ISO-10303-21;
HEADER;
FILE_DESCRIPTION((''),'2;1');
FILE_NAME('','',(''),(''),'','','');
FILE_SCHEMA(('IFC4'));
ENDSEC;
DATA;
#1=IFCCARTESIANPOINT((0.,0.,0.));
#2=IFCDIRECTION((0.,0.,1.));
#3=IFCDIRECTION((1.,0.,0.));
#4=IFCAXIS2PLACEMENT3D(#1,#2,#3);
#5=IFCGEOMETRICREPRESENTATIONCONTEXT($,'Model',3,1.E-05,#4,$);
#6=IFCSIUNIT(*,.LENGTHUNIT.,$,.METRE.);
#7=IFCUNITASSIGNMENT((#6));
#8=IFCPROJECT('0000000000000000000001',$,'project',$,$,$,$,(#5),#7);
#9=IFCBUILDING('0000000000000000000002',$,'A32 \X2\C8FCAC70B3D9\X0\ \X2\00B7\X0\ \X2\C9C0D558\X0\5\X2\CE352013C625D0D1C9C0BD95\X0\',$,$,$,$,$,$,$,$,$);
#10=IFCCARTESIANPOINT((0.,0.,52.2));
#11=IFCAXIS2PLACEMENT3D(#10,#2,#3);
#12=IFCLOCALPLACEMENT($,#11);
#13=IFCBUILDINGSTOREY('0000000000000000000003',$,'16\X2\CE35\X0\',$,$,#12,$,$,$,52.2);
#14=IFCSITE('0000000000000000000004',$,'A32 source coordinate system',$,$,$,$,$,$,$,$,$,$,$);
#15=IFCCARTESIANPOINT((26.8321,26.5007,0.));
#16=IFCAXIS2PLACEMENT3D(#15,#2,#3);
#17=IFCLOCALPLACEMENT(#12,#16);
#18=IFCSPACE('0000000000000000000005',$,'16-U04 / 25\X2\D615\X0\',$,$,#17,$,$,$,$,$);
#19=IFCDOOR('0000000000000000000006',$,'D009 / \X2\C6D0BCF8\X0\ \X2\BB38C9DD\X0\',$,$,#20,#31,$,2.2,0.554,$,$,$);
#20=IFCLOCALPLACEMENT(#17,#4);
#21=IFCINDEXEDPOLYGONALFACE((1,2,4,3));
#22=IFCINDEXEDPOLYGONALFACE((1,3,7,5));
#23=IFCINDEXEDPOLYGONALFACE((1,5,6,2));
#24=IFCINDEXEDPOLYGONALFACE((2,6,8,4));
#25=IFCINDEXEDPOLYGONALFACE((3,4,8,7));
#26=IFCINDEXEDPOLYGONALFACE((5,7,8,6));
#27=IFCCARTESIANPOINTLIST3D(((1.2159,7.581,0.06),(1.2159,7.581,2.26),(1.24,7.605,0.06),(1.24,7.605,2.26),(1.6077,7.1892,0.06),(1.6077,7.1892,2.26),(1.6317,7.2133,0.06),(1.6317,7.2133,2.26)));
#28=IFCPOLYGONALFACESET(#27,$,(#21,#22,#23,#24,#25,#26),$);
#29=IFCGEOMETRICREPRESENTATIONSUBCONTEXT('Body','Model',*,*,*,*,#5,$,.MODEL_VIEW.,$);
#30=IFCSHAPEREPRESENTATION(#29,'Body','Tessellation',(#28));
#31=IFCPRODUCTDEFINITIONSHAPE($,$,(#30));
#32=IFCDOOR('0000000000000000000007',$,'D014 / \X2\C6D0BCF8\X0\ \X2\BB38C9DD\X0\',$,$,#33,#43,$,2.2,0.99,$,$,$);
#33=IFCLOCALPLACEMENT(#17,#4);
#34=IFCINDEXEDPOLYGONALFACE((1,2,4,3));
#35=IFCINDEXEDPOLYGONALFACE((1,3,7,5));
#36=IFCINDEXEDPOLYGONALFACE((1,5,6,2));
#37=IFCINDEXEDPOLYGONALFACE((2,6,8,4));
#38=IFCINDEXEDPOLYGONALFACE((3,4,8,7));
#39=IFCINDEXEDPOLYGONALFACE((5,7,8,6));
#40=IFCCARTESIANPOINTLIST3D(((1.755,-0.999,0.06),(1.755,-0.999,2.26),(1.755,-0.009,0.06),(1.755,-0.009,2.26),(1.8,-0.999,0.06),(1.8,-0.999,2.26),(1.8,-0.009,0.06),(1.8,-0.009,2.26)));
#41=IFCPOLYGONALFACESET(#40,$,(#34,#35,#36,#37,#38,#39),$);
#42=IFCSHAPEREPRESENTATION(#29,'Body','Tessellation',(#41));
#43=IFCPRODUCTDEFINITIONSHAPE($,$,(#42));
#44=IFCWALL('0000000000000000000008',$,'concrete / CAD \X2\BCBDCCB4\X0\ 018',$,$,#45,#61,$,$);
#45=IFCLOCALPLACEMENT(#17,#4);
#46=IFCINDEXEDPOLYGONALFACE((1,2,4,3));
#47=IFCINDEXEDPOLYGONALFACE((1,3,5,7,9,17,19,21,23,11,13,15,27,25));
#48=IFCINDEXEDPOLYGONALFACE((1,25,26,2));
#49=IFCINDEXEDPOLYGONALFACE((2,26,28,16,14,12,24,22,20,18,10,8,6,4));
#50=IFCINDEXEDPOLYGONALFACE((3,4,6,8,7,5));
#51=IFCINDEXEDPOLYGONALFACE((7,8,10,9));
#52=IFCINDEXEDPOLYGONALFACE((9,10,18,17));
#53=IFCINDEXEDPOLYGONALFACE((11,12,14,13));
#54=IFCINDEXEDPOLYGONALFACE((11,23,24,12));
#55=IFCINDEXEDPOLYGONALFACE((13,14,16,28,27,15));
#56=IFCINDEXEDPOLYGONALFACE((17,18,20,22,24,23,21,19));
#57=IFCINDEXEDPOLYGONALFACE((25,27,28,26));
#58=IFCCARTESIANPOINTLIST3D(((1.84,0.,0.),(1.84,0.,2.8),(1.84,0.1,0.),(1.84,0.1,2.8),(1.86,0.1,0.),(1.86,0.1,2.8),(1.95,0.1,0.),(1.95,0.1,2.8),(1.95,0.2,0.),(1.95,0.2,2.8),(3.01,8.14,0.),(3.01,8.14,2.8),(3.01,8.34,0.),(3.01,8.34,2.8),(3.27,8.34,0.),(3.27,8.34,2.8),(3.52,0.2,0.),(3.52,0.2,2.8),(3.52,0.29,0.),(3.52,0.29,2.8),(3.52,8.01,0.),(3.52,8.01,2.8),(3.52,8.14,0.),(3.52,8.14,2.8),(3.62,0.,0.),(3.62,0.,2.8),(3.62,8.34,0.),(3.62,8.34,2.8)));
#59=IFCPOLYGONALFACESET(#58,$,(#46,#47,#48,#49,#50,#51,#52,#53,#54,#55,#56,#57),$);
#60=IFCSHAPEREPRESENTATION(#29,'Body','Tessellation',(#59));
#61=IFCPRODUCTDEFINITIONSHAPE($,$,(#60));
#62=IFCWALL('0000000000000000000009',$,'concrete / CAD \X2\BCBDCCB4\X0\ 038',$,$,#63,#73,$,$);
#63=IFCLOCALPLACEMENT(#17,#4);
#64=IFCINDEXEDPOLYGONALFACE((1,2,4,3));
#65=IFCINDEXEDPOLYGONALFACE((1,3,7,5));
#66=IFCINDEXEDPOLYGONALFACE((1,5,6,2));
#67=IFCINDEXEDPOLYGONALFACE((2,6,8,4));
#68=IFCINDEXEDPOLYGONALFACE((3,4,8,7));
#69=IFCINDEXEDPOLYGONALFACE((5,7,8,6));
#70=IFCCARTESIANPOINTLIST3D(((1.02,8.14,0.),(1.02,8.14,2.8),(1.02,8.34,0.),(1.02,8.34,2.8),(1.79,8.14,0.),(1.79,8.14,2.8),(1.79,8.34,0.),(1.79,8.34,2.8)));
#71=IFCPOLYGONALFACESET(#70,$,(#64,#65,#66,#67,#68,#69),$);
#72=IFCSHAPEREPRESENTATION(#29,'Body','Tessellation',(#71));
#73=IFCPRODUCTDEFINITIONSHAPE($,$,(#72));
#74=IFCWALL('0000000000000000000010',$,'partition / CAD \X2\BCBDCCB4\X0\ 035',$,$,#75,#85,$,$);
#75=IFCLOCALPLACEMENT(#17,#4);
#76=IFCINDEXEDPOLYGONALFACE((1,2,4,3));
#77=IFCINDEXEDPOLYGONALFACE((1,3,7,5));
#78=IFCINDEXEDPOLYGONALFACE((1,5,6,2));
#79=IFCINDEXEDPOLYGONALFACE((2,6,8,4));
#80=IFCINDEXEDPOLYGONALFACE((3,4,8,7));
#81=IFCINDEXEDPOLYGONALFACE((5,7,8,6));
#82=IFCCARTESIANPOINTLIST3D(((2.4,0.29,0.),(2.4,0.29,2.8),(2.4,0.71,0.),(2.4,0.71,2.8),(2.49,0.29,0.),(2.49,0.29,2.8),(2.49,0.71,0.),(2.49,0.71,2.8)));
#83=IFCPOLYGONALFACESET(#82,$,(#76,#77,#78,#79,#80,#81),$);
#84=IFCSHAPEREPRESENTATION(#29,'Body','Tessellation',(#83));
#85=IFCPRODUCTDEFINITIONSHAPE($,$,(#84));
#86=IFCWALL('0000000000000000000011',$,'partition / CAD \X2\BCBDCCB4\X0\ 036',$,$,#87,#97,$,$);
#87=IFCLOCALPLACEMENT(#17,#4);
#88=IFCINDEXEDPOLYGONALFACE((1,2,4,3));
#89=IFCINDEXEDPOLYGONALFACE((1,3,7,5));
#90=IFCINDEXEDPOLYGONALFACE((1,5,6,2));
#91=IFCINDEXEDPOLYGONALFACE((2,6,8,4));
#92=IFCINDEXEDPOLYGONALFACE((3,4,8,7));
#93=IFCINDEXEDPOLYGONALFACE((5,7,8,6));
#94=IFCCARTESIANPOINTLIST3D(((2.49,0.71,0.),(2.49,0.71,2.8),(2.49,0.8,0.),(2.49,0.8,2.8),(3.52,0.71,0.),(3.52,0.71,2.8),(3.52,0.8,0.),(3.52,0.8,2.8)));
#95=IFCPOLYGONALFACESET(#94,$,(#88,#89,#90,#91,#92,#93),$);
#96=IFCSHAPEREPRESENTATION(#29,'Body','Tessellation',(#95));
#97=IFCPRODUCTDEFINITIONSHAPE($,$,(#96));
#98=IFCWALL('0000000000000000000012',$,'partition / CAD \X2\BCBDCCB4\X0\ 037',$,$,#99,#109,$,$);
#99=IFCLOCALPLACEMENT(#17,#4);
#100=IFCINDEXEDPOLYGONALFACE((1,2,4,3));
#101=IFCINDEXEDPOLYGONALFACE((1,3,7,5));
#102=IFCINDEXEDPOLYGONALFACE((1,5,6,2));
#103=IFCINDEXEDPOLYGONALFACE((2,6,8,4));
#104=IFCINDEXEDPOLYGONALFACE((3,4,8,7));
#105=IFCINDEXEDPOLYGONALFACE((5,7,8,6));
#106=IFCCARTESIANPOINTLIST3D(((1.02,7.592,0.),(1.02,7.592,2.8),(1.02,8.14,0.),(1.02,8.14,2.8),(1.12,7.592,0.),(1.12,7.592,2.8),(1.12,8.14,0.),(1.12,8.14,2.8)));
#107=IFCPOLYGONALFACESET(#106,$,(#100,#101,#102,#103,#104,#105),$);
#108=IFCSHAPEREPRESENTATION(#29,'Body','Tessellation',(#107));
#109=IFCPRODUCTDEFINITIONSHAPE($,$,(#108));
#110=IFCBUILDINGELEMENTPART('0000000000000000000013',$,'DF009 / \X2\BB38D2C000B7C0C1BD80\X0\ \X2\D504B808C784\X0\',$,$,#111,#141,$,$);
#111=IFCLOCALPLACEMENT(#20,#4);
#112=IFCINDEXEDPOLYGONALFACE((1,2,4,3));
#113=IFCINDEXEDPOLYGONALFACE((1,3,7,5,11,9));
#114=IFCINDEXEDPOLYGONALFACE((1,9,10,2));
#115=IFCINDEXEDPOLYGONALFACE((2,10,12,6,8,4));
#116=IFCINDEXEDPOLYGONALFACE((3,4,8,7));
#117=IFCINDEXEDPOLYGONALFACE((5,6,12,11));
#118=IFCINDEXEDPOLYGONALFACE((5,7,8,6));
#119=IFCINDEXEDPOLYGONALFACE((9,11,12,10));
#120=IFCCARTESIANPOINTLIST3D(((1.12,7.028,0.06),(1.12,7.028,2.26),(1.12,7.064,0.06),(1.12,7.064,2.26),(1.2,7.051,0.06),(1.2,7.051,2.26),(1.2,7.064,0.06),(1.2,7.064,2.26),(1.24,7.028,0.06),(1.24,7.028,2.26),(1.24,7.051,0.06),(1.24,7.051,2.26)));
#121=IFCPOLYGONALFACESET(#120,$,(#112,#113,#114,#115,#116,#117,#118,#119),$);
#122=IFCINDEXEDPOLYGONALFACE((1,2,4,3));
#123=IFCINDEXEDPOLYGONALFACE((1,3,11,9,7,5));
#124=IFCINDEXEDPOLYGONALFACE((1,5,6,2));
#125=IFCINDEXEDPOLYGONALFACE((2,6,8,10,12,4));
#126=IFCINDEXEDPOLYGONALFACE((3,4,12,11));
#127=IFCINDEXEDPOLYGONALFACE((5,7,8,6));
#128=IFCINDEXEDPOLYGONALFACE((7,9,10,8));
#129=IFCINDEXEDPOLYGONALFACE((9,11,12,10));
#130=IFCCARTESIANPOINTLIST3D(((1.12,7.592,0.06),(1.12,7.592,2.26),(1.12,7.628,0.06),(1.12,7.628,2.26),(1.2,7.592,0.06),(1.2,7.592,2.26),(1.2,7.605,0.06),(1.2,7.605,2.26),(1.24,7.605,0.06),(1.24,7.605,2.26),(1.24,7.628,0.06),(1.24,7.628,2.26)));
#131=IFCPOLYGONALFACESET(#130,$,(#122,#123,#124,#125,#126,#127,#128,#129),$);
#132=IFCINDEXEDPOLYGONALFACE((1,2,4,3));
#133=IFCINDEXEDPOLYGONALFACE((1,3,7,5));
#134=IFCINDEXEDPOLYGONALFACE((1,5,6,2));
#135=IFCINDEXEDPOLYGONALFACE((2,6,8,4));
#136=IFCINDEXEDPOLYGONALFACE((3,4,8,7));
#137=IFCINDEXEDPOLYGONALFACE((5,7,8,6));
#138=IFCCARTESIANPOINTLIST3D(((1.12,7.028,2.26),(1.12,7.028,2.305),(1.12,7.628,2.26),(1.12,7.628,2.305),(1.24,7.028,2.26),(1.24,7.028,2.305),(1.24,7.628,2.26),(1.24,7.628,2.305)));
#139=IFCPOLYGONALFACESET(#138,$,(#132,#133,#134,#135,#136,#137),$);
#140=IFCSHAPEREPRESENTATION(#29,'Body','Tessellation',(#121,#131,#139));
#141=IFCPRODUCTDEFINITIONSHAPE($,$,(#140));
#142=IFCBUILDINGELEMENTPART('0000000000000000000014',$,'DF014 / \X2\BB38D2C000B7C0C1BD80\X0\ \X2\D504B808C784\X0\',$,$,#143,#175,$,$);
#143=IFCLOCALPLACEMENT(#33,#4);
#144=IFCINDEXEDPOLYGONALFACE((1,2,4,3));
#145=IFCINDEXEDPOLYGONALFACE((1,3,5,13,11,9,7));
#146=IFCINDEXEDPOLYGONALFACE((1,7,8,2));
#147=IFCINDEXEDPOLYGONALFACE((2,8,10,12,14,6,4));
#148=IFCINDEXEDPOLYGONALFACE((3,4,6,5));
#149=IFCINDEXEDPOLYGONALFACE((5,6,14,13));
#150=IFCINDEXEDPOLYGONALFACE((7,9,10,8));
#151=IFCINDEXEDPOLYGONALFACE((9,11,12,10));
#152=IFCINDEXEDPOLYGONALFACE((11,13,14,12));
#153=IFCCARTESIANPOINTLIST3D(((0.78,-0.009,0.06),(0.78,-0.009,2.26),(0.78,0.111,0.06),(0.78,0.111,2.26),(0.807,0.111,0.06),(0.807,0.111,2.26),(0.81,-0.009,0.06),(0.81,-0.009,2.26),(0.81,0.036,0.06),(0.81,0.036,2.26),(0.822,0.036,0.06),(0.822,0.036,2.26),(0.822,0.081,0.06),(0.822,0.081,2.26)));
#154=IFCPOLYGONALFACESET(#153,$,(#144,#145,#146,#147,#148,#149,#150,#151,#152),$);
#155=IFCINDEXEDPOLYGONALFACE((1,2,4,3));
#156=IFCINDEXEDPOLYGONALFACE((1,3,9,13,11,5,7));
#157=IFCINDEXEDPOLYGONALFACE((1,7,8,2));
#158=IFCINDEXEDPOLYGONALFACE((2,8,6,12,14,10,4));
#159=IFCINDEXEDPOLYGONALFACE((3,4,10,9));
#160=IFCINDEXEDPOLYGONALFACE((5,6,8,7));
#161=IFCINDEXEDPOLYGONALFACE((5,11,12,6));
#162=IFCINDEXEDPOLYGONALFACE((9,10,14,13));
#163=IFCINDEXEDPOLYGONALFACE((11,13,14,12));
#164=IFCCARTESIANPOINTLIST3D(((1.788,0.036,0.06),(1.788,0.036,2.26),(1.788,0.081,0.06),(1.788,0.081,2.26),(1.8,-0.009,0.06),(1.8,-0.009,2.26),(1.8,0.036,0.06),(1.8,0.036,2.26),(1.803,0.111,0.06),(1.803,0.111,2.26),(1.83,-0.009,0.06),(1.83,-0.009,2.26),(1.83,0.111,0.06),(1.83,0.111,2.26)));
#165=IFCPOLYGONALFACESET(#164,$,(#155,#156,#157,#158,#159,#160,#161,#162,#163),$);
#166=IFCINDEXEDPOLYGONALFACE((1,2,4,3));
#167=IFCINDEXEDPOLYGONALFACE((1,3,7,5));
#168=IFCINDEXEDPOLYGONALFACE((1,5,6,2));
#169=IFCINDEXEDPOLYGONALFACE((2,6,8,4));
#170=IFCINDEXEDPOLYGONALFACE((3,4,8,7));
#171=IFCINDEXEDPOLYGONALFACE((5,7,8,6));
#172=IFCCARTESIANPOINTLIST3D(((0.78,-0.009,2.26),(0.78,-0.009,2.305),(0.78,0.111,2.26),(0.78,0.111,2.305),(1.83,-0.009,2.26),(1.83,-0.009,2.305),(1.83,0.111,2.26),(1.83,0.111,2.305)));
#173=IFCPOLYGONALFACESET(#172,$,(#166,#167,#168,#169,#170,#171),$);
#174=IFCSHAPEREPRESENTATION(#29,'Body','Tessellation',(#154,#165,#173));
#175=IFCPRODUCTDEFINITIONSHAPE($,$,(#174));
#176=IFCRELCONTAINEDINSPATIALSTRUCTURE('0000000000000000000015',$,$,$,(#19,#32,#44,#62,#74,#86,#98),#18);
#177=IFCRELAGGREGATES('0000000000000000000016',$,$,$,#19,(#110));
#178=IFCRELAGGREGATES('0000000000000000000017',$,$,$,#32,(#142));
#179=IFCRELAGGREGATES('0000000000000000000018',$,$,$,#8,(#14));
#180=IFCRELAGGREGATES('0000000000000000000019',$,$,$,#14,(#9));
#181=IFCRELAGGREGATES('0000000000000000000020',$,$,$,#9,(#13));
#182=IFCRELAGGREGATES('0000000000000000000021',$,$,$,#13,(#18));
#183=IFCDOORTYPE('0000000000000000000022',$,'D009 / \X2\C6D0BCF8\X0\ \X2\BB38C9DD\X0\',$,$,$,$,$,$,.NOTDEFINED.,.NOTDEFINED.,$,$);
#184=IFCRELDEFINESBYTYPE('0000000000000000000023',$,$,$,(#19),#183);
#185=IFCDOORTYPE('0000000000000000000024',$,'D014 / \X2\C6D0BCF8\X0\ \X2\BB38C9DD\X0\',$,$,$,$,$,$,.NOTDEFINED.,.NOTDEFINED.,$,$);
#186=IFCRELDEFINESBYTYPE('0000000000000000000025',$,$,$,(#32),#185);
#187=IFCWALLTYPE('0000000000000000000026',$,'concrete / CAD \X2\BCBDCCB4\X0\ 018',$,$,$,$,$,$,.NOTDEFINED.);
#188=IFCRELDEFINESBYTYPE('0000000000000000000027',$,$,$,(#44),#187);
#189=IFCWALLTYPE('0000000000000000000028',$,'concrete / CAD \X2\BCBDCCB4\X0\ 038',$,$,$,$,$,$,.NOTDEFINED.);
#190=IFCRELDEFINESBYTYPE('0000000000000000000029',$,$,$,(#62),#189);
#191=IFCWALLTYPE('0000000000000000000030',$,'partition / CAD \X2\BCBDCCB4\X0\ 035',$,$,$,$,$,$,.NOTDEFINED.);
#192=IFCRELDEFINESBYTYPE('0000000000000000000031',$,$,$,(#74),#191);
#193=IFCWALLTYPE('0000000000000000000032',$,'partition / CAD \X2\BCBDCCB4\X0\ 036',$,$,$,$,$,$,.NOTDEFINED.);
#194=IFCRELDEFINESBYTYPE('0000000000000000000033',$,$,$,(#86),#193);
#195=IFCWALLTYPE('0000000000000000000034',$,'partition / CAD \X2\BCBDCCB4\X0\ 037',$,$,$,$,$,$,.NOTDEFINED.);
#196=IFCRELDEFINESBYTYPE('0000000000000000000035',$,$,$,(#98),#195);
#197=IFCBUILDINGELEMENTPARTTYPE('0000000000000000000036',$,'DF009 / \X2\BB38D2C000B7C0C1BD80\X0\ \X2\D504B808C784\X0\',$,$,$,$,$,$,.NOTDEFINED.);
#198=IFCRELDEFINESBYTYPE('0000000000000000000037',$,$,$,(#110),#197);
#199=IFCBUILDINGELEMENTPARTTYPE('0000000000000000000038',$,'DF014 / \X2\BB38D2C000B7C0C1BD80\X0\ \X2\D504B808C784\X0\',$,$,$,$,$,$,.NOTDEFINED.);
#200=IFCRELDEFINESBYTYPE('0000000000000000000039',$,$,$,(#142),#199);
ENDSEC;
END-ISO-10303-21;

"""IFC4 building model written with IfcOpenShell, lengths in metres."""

from ifc_helpers import new_model, si_unit, frame, origin, origin_with_axes, place, context, subcontext, project, spatial, polyline, outline, extrude, source, transform, mapped, type_object, type_shapes, element, aggregate, save


model = new_model("IFC4")

# Units and contexts
model_context = context("Model", 3, precision=1e-05, world=origin_with_axes())
body_context = subcontext(model_context, "Body", "Model", "MODEL_VIEW")
ifc_project = project(units=[si_unit("LENGTHUNIT", "METRE")], contexts=[model_context])

# Site, building, storey, space
storey_placement = place(None, frame((0.0, 0.0, 52.2), z_axis=(0.0, 0.0, 1.0), x_axis=(1.0, 0.0, 0.0)))
space_placement = place(storey_placement, frame((26.8321, 26.5007, 0.0), z_axis=(0.0, 0.0, 1.0), x_axis=(1.0, 0.0, 0.0)))
site = spatial("IfcSite", under=ifc_project, Name="A32 source coordinate system")
building = spatial("IfcBuilding", under=site, Name="A32 주거동 · 지하5층–옥탑지붕")
storey = spatial("IfcBuildingStorey", under=building, at=storey_placement, Name="16층", Elevation=52.2)
space = spatial("IfcSpace", under=storey, at=space_placement, Name="16-U04 / 25형")

# Doors
door_type_1 = type_object("IfcDoorType", Name="D009 / 원본 문짝", OperationType="NOTDEFINED", PredefinedType="NOTDEFINED")
shared_shape_1 = source(origin(), body_context, "Body", "SweptSolid", [
    extrude(outline(polyline([(1.24, 7.605), (1.6317, 7.2133), (1.6077, 7.1892), (1.2159, 7.581), (1.24, 7.605)])), frame((0.0, 0.0, 0.06)), (0.0, 0.0, 1.0), 2.2),
])
type_shapes(door_type_1, [shared_shape_1])
door_1_placement = place(space_placement, origin_with_axes())
door_1 = element("IfcDoor", 1, at=door_1_placement, inside=space, type_object=door_type_1, Name="D009 / 원본 문짝", OverallHeight=2.2, OverallWidth=0.554, context=body_context, shape_type="MappedRepresentation", body=[
    mapped(shared_shape_1, transform((0.0, 0.0, 0.0), scale=1.0)),
])
door_type_2 = type_object("IfcDoorType", Name="D014 / 원본 문짝", OperationType="NOTDEFINED", PredefinedType="NOTDEFINED")
shared_shape_2 = source(origin(), body_context, "Body", "SweptSolid", [
    extrude(outline(polyline([(1.8, -0.009), (1.8, -0.999), (1.755, -0.999), (1.755, -0.009), (1.8, -0.009)])), frame((0.0, 0.0, 0.06)), (0.0, 0.0, 1.0), 2.2),
])
type_shapes(door_type_2, [shared_shape_2])
door_2_placement = place(space_placement, origin_with_axes())
door_2 = element("IfcDoor", 2, at=door_2_placement, inside=space, type_object=door_type_2, Name="D014 / 원본 문짝", OverallHeight=2.2, OverallWidth=0.99, context=body_context, shape_type="MappedRepresentation", body=[
    mapped(shared_shape_2, transform((0.0, 0.0, 0.0), scale=1.0)),
])

# Walls
wall_type_1 = type_object("IfcWallType", Name="concrete / CAD 벽체 018", PredefinedType="NOTDEFINED")
shared_shape_3 = source(origin(), body_context, "Body", "SweptSolid", [
    extrude(outline(polyline([(3.27, 8.34), (3.27, 8.34), (3.62, 8.34), (3.62, 0.0), (1.84, 0.0), (1.84, 0.1), (1.86, 0.1), (1.95, 0.1), (1.95, 0.2), (3.52, 0.2), (3.52, 0.29), (3.52, 8.01), (3.52, 8.14), (3.01, 8.14), (3.01, 8.34), (3.27, 8.34)])), origin(), (0.0, 0.0, 1.0), 2.8),
])
type_shapes(wall_type_1, [shared_shape_3])
wall_1_placement = place(space_placement, origin_with_axes())
element("IfcWall", 3, at=wall_1_placement, inside=space, type_object=wall_type_1, Name="concrete / CAD 벽체 018", context=body_context, shape_type="MappedRepresentation", body=[
    mapped(shared_shape_3, transform((0.0, 0.0, 0.0), scale=1.0)),
])
wall_type_2 = type_object("IfcWallType", Name="concrete / CAD 벽체 038", PredefinedType="NOTDEFINED")
shared_shape_4 = source(origin(), body_context, "Body", "SweptSolid", [
    extrude(outline(polyline([(1.02, 8.14), (1.02, 8.34), (1.79, 8.34), (1.79, 8.14), (1.02, 8.14)])), origin(), (0.0, 0.0, 1.0), 2.8),
])
type_shapes(wall_type_2, [shared_shape_4])
wall_2_placement = place(space_placement, origin_with_axes())
element("IfcWall", 4, at=wall_2_placement, inside=space, type_object=wall_type_2, Name="concrete / CAD 벽체 038", context=body_context, shape_type="MappedRepresentation", body=[
    mapped(shared_shape_4, transform((0.0, 0.0, 0.0), scale=1.0)),
])
wall_type_3 = type_object("IfcWallType", Name="partition / CAD 벽체 035", PredefinedType="NOTDEFINED")
shared_shape_5 = source(origin(), body_context, "Body", "SweptSolid", [
    extrude(outline(polyline([(2.49, 0.71), (2.49, 0.29), (2.4, 0.29), (2.4, 0.71), (2.49, 0.71)])), origin(), (0.0, 0.0, 1.0), 2.8),
])
type_shapes(wall_type_3, [shared_shape_5])
wall_3_placement = place(space_placement, origin_with_axes())
element("IfcWall", 5, at=wall_3_placement, inside=space, type_object=wall_type_3, Name="partition / CAD 벽체 035", context=body_context, shape_type="MappedRepresentation", body=[
    mapped(shared_shape_5, transform((0.0, 0.0, 0.0), scale=1.0)),
])
wall_type_4 = type_object("IfcWallType", Name="partition / CAD 벽체 036", PredefinedType="NOTDEFINED")
shared_shape_6 = source(origin(), body_context, "Body", "SweptSolid", [
    extrude(outline(polyline([(2.49, 0.8), (3.52, 0.8), (3.52, 0.71), (2.49, 0.71), (2.49, 0.8)])), origin(), (0.0, 0.0, 1.0), 2.8),
])
type_shapes(wall_type_4, [shared_shape_6])
wall_4_placement = place(space_placement, origin_with_axes())
element("IfcWall", 6, at=wall_4_placement, inside=space, type_object=wall_type_4, Name="partition / CAD 벽체 036", context=body_context, shape_type="MappedRepresentation", body=[
    mapped(shared_shape_6, transform((0.0, 0.0, 0.0), scale=1.0)),
])
wall_type_5 = type_object("IfcWallType", Name="partition / CAD 벽체 037", PredefinedType="NOTDEFINED")
shared_shape_7 = source(origin(), body_context, "Body", "SweptSolid", [
    extrude(outline(polyline([(1.02, 7.592), (1.02, 8.14), (1.12, 8.14), (1.12, 7.592), (1.02, 7.592)])), origin(), (0.0, 0.0, 1.0), 2.8),
])
type_shapes(wall_type_5, [shared_shape_7])
wall_5_placement = place(space_placement, origin_with_axes())
element("IfcWall", 7, at=wall_5_placement, inside=space, type_object=wall_type_5, Name="partition / CAD 벽체 037", context=body_context, shape_type="MappedRepresentation", body=[
    mapped(shared_shape_7, transform((0.0, 0.0, 0.0), scale=1.0)),
])

# Building element parts
building_element_part_type_1 = type_object("IfcBuildingElementPartType", Name="DF009 / 문틀·상부 프레임", PredefinedType="NOTDEFINED")
shared_shape_8 = source(origin(), body_context, "Body", "SweptSolid", [
    extrude(outline(polyline([(1.12, 7.064), (1.2, 7.064), (1.2, 7.051), (1.24, 7.051), (1.24, 7.028), (1.12, 7.028), (1.12, 7.064)])), frame((0.0, 0.0, 0.06)), (0.0, 0.0, 1.0), 2.2),
    extrude(outline(polyline([(1.24, 7.628), (1.24, 7.605), (1.2, 7.605), (1.2, 7.592), (1.12, 7.592), (1.12, 7.628), (1.24, 7.628)])), frame((0.0, 0.0, 0.06)), (0.0, 0.0, 1.0), 2.2),
    extrude(outline(polyline([(1.12, 7.028), (1.12, 7.628), (1.24, 7.628), (1.24, 7.028), (1.12, 7.028)])), frame((0.0, 0.0, 2.26)), (0.0, 0.0, 1.0), 0.045),
])
type_shapes(building_element_part_type_1, [shared_shape_8])
building_element_part_1_placement = place(door_1_placement, origin_with_axes())
building_element_part_1 = element("IfcBuildingElementPart", 8, at=building_element_part_1_placement, type_object=building_element_part_type_1, Name="DF009 / 문틀·상부 프레임", context=body_context, shape_type="MappedRepresentation", body=[
    mapped(shared_shape_8, transform((0.0, 0.0, 0.0), scale=1.0)),
])
aggregate(door_1, [building_element_part_1])
building_element_part_type_2 = type_object("IfcBuildingElementPartType", Name="DF014 / 문틀·상부 프레임", PredefinedType="NOTDEFINED")
shared_shape_9 = source(origin(), body_context, "Body", "SweptSolid", [
    extrude(outline(polyline([(0.78, 0.111), (0.807, 0.111), (0.822, 0.081), (0.822, 0.036), (0.81, 0.036), (0.81, -0.009), (0.78, -0.009), (0.78, 0.111)])), frame((0.0, 0.0, 0.06)), (0.0, 0.0, 1.0), 2.2),
    extrude(outline(polyline([(1.8, -0.009), (1.8, 0.036), (1.788, 0.036), (1.788, 0.081), (1.803, 0.111), (1.83, 0.111), (1.83, -0.009), (1.8, -0.009)])), frame((0.0, 0.0, 0.06)), (0.0, 0.0, 1.0), 2.2),
    extrude(outline(polyline([(0.78, -0.009), (0.78, 0.111), (1.83, 0.111), (1.83, -0.009), (0.78, -0.009)])), frame((0.0, 0.0, 2.26)), (0.0, 0.0, 1.0), 0.045),
])
type_shapes(building_element_part_type_2, [shared_shape_9])
building_element_part_2_placement = place(door_2_placement, origin_with_axes())
building_element_part_2 = element("IfcBuildingElementPart", 9, at=building_element_part_2_placement, type_object=building_element_part_type_2, Name="DF014 / 문틀·상부 프레임", context=body_context, shape_type="MappedRepresentation", body=[
    mapped(shared_shape_9, transform((0.0, 0.0, 0.0), scale=1.0)),
])
aggregate(door_2, [building_element_part_2])

save(model, "model.ifc")
